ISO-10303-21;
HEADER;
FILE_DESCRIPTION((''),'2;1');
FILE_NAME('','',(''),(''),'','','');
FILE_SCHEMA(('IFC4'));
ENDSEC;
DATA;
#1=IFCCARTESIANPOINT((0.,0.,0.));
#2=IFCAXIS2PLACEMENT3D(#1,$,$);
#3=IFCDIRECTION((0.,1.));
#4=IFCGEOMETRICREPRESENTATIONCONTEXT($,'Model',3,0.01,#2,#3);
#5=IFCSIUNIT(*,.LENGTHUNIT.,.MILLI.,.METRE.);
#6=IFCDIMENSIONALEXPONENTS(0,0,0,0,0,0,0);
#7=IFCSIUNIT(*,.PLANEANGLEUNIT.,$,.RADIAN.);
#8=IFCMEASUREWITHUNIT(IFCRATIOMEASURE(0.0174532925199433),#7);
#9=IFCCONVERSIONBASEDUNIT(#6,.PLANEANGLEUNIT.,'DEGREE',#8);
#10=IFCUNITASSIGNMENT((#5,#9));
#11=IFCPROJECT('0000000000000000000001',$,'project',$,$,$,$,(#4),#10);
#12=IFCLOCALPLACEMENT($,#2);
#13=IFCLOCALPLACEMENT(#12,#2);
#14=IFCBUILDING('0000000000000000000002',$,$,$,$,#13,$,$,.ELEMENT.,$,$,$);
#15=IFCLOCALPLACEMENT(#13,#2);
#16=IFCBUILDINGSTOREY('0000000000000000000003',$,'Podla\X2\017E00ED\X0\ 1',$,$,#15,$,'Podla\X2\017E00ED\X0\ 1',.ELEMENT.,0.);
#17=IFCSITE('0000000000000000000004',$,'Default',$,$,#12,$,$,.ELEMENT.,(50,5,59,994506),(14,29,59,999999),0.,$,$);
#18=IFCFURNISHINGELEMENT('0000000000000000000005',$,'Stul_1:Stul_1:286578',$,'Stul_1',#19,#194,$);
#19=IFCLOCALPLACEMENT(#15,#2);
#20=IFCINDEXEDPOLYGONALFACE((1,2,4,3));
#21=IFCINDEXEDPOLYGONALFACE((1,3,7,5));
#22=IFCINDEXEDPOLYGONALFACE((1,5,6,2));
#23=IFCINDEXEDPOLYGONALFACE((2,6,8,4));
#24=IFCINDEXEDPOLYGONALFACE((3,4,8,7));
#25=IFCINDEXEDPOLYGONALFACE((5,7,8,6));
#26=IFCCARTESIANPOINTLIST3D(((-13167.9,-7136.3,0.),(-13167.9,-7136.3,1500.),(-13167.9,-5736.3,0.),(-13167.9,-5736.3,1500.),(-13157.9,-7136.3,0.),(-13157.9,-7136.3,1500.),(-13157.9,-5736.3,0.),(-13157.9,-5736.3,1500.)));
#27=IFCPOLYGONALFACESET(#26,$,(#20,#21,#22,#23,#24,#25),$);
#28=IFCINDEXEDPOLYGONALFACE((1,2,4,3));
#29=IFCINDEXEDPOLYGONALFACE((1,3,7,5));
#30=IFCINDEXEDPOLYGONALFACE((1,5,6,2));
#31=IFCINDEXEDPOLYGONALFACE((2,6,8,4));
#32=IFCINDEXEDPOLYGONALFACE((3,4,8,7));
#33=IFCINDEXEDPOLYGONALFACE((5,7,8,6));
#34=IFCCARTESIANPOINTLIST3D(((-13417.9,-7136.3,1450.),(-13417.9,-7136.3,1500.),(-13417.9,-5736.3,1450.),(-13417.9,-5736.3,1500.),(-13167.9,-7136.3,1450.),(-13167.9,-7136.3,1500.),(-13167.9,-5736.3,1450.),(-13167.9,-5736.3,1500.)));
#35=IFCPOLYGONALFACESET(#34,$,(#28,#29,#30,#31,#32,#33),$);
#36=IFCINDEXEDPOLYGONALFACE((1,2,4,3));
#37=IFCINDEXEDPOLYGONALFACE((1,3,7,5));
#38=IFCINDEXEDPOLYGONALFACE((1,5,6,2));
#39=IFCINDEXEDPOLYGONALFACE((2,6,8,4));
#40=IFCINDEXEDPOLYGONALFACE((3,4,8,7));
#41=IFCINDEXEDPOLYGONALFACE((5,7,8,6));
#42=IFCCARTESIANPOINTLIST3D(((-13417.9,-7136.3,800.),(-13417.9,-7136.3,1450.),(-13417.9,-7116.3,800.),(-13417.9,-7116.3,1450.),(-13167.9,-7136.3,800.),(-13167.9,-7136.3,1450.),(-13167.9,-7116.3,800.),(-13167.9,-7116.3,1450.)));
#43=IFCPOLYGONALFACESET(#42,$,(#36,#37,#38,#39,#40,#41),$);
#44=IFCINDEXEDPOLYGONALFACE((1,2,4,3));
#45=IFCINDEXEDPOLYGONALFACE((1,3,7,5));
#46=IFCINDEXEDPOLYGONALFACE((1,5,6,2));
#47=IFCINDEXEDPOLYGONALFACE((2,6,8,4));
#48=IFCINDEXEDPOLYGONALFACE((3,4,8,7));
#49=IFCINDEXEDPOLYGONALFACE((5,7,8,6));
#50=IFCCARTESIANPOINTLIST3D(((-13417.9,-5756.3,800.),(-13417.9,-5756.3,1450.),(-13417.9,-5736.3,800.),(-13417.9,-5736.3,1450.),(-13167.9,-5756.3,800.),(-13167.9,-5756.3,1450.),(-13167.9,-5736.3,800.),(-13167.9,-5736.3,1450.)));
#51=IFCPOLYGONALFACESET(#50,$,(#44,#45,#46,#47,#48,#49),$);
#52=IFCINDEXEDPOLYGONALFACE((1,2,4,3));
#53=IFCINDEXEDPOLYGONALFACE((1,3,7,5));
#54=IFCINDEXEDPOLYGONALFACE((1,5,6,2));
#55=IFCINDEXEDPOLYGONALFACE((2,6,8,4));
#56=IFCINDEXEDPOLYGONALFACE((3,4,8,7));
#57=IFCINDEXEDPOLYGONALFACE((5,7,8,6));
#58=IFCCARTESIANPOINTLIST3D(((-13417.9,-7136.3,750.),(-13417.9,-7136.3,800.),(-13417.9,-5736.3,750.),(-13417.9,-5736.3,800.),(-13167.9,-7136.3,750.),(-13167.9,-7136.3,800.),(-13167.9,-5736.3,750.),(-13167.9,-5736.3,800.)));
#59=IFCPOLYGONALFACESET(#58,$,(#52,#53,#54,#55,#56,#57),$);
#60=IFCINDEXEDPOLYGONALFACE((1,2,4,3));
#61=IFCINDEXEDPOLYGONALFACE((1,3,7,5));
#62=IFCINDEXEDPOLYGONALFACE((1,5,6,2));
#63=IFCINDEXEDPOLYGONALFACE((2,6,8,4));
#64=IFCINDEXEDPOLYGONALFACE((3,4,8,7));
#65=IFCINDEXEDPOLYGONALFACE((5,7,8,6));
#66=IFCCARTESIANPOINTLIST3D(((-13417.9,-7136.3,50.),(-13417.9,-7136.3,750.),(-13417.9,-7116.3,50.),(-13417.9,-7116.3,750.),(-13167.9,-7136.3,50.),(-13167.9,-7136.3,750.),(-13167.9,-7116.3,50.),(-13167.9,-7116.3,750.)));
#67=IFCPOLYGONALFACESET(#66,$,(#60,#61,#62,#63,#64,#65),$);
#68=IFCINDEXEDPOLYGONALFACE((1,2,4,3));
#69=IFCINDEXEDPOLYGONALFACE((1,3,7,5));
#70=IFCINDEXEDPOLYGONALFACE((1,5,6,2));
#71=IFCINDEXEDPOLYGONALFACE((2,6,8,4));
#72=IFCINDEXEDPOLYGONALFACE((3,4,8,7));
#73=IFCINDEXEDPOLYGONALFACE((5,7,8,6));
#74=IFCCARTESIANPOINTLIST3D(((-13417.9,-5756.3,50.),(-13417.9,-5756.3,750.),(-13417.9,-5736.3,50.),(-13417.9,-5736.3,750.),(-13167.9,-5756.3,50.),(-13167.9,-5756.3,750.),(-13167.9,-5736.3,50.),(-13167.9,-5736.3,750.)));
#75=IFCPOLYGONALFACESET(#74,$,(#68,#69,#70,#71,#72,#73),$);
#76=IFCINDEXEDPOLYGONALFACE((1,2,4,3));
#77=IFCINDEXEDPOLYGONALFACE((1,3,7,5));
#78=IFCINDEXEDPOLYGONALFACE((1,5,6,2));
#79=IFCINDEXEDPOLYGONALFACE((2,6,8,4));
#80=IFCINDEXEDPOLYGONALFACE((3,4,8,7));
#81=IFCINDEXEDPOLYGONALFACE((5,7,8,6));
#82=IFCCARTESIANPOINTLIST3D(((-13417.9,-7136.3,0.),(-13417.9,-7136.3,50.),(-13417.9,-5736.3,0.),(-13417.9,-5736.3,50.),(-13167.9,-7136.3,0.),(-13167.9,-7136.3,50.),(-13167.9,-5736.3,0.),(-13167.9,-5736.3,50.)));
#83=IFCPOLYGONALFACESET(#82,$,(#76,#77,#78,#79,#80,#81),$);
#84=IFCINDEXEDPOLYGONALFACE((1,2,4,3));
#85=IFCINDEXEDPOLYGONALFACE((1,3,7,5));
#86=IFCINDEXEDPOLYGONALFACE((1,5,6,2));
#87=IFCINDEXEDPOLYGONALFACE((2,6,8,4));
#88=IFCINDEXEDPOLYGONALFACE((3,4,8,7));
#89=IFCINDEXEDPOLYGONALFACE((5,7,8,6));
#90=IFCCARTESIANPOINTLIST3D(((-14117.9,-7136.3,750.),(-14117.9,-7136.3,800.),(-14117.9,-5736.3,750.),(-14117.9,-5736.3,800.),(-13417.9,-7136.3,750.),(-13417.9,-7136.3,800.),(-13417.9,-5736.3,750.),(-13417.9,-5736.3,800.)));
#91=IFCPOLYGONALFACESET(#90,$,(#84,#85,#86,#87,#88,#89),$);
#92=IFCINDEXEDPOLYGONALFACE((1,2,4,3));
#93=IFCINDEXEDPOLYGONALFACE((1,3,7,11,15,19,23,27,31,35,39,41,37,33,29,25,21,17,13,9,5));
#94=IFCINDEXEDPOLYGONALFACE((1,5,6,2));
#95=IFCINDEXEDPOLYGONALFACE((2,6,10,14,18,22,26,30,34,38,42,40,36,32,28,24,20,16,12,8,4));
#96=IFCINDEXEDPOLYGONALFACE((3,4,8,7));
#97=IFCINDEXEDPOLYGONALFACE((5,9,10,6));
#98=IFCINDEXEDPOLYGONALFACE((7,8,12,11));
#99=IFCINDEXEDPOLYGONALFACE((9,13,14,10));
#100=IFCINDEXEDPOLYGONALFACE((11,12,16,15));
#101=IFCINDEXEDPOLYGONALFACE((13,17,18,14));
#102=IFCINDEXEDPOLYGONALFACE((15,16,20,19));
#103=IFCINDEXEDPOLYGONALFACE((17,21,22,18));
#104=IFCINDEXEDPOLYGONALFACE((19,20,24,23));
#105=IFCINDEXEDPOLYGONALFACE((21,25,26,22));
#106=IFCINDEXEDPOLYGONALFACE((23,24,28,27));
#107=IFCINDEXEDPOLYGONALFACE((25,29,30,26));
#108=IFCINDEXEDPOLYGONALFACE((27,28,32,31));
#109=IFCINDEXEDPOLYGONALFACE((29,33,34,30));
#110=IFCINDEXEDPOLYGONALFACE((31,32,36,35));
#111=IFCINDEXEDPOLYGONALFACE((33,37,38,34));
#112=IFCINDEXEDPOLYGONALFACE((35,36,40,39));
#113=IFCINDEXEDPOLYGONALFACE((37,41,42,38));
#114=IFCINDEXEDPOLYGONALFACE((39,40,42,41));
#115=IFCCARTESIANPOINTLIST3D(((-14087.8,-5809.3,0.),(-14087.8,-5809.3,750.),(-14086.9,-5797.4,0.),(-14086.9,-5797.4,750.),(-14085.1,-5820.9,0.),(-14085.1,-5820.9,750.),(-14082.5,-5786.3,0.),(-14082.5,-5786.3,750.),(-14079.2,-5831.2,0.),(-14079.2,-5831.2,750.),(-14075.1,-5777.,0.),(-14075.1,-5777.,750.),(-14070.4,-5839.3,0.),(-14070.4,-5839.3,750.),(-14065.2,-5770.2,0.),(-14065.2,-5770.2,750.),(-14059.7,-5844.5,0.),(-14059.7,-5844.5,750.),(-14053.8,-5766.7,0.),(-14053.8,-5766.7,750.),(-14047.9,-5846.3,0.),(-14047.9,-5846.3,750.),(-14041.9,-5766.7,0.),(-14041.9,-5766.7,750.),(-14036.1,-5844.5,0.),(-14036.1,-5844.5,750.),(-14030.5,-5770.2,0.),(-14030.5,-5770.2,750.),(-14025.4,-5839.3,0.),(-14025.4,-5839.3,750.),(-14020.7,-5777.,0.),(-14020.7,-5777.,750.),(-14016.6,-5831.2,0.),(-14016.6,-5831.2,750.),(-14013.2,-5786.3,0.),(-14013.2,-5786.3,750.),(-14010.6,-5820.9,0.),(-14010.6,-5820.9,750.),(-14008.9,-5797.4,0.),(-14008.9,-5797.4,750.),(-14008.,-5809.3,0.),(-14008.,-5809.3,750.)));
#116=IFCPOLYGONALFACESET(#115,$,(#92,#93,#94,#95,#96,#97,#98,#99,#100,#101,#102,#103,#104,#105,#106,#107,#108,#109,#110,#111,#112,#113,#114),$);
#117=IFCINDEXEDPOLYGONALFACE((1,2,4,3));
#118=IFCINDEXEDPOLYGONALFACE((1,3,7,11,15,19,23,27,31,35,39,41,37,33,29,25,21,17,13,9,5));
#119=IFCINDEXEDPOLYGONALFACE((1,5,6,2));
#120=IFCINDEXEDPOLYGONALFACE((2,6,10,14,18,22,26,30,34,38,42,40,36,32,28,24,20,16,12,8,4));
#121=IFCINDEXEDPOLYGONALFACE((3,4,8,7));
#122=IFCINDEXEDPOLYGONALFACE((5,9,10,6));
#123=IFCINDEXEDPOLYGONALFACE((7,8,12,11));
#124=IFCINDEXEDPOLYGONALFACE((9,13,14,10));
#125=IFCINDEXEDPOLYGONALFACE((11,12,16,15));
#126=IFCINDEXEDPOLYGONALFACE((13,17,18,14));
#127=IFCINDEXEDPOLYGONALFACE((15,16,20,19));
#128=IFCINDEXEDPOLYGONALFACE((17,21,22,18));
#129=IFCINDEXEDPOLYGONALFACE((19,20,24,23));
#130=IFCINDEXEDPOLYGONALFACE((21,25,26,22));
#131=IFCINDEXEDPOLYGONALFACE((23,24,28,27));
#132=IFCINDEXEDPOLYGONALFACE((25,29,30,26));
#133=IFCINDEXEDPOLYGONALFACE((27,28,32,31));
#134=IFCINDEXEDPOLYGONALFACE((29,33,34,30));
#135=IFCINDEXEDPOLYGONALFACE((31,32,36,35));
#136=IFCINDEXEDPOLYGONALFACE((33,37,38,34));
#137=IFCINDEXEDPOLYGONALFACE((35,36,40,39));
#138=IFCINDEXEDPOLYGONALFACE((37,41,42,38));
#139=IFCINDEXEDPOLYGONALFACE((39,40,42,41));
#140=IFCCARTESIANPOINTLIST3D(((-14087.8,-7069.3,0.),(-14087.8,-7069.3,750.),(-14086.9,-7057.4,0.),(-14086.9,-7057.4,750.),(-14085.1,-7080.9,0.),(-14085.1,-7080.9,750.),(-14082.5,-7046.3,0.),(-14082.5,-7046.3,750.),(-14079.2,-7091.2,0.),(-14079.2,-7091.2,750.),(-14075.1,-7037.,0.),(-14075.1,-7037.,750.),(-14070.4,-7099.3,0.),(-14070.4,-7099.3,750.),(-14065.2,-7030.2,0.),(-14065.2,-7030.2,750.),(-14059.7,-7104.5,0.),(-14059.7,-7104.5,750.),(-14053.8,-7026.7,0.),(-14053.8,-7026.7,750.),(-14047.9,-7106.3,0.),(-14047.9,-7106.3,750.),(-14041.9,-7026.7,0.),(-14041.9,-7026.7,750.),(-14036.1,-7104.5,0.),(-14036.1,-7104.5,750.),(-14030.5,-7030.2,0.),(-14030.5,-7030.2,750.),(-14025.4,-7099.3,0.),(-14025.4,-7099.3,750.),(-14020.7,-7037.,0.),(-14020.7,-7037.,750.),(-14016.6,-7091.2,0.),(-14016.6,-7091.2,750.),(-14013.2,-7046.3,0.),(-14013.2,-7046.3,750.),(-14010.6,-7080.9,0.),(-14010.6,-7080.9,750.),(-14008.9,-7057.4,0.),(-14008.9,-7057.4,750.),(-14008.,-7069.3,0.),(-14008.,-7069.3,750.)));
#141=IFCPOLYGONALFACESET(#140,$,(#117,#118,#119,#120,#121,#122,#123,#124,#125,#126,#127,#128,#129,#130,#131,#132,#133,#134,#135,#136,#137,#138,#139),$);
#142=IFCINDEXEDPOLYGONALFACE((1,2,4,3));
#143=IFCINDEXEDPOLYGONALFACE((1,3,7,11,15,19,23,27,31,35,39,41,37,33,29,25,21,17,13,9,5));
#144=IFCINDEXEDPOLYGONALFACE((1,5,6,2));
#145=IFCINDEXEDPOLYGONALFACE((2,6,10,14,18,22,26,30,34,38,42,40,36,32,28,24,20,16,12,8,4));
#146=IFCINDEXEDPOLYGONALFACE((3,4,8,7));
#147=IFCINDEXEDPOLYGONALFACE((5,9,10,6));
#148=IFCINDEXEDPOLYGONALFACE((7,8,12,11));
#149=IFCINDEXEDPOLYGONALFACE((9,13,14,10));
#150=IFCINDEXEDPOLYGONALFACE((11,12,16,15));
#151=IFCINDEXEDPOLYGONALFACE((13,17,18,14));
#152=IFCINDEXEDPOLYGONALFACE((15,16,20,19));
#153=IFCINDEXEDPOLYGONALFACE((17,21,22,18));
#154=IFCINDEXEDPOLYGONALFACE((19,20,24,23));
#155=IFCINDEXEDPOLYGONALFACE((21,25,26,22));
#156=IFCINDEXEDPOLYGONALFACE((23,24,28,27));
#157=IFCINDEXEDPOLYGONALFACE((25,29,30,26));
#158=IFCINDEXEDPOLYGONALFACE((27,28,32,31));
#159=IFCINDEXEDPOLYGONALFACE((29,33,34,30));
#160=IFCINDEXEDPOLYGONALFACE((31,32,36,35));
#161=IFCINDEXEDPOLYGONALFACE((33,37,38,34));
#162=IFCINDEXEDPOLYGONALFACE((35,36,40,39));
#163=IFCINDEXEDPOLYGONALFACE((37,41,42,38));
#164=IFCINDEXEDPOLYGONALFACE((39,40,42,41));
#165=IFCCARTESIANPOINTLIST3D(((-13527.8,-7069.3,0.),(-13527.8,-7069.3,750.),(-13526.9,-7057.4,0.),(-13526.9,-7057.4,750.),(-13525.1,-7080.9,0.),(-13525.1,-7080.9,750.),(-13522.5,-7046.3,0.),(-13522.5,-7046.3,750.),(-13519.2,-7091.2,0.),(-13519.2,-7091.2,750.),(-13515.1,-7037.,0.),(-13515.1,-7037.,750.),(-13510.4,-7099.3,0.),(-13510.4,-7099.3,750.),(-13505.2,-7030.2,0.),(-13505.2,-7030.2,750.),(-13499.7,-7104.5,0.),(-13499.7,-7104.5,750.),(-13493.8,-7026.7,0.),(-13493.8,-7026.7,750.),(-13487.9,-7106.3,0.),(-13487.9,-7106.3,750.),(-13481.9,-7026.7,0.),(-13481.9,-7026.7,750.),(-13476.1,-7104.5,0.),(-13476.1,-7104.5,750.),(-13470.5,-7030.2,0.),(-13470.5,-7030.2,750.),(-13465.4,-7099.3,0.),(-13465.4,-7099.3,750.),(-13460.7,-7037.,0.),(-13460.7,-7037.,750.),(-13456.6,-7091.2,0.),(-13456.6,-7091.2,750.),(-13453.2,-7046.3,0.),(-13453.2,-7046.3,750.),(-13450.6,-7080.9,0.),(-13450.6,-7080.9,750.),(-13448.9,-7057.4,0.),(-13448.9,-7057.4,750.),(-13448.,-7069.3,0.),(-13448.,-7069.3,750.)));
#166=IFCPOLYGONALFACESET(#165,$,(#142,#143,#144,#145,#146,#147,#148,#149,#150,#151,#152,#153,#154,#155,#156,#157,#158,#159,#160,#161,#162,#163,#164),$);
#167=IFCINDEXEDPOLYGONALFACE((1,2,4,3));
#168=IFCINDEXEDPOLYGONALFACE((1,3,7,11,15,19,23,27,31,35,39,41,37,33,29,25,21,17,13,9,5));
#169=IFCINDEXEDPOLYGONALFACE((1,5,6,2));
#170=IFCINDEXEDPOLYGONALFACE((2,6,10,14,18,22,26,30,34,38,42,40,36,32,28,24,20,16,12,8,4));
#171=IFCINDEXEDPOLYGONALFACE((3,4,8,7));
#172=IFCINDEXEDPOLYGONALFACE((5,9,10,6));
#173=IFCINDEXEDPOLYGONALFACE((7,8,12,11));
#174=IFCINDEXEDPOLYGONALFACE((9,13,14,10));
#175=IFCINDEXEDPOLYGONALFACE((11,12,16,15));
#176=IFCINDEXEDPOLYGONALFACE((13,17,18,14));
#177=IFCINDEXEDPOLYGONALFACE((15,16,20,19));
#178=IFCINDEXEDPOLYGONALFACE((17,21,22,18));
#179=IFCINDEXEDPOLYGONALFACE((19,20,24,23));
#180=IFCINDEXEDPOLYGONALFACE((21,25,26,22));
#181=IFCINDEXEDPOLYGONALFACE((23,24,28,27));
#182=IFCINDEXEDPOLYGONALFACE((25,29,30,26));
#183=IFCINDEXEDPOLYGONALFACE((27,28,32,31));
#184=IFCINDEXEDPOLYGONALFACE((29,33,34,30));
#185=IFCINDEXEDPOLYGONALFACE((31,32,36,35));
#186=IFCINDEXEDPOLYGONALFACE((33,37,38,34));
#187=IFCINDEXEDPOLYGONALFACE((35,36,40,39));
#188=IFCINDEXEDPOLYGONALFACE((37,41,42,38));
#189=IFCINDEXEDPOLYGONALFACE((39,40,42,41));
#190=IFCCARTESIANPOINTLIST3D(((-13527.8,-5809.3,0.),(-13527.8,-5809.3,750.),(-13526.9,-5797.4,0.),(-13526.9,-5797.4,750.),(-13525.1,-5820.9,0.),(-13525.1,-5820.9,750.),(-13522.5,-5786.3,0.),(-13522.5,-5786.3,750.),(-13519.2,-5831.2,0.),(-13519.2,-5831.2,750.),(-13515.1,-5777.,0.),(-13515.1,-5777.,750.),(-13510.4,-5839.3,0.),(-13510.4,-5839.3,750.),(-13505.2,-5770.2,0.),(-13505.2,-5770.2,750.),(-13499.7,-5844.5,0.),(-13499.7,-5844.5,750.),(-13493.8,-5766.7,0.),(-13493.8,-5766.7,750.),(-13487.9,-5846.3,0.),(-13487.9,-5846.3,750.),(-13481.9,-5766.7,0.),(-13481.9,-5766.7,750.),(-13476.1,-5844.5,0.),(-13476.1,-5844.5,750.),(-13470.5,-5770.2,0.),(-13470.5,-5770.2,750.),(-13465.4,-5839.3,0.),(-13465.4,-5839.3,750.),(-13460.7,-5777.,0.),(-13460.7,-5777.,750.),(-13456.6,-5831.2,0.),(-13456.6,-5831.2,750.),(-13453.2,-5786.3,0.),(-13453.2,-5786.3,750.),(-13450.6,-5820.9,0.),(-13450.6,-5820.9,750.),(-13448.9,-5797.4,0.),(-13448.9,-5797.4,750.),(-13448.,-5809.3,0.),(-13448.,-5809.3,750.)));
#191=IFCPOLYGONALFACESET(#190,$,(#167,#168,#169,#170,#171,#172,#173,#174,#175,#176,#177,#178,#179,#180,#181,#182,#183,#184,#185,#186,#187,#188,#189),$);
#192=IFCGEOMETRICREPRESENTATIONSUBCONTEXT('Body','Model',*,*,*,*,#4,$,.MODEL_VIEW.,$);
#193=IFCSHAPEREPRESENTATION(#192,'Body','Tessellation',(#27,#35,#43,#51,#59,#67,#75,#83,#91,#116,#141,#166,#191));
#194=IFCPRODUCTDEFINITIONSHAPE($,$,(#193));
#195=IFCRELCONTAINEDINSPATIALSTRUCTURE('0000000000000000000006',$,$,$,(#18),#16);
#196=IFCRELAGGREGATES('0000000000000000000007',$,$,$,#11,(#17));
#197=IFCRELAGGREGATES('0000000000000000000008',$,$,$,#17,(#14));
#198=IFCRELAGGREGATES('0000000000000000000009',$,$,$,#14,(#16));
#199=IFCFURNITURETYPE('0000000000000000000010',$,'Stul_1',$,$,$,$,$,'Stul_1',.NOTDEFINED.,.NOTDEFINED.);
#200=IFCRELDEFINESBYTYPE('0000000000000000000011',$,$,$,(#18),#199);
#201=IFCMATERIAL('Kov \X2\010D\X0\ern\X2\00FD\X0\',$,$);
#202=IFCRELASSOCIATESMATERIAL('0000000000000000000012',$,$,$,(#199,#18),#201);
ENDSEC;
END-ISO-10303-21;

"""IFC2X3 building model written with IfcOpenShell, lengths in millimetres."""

from ifc_helpers import new_model, entity, si_unit, converted_unit, direction, frame, frame_2d, origin, origin_2d_with_axis, place, context, subcontext, project, spatial, rectangle, circle, extrude, source, transform, mapped, material, type_object, type_shapes, element, save


model = new_model("IFC2X3")

# Units and contexts
model_context = context("Model", 3, precision=0.01, world=origin(), true_north=direction((0.0, 1.0)))
body_context = subcontext(model_context, "Body", "Model", "MODEL_VIEW")
ifc_project = project(units=[si_unit("LENGTHUNIT", "METRE", prefix="MILLI"), converted_unit("PLANEANGLEUNIT", "DEGREE", entity("IfcRatioMeasure", 0.0174532925199433), si_unit("PLANEANGLEUNIT", "RADIAN"), dimensions=[0, 0, 0, 0, 0, 0, 0])], contexts=[model_context])

# Site, building, storey
site_placement = place(None, origin())
site = spatial("IfcSite", under=ifc_project, at=site_placement, Name="Default", CompositionType="ELEMENT", RefLatitude=(50, 5, 59, 994506), RefLongitude=(14, 29, 59, 999999), RefElevation=0.0)
building_placement = place(site_placement, origin())
building = spatial("IfcBuilding", under=site, at=building_placement, CompositionType="ELEMENT")
storey_placement = place(building_placement, origin())
storey = spatial("IfcBuildingStorey", under=building, at=storey_placement, Name="Podlaží 1", LongName="Podlaží 1", CompositionType="ELEMENT", Elevation=0.0)

# Furnishing element
ifc_material_1 = material(Name="Kov černý")
furniture_type = type_object("IfcFurnitureType", Name="Stul_1", ElementType="Stul_1", material=ifc_material_1)
shared_shape_1 = source(origin(), body_context, "Body", "SweptSolid", [
    extrude(rectangle(XDim=1400.0, YDim=10.0, at=origin_2d_with_axis()), frame((0.0, 605.0, 0.0), z_axis=(0.0, 0.0, 1.0), x_axis=(-1.0, 0.0, 0.0)), (0.0, 0.0, 1.0), 1500.0),
    extrude(rectangle(XDim=1400.0, YDim=250.0, at=frame_2d((0.0, 0.0), x_axis=(1.0, 0.0))), frame((0.0, 475.0, 1450.0), z_axis=(0.0, 0.0, 1.0), x_axis=(-1.0, 0.0, 0.0)), (0.0, 0.0, 1.0), 50.0),
    extrude(rectangle(XDim=20.0, YDim=250.0, at=origin_2d_with_axis()), frame((690.0, 475.0, 800.0), z_axis=(0.0, 0.0, 1.0), x_axis=(-1.0, 0.0, 0.0)), (0.0, 0.0, 1.0), 650.0),
    extrude(rectangle(XDim=20.0, YDim=250.0, at=frame_2d((0.0, 0.0), x_axis=(1.0, 0.0))), frame((-690.0, 475.0, 800.0), z_axis=(0.0, 0.0, 1.0), x_axis=(-1.0, 0.0, 0.0)), (0.0, 0.0, 1.0), 650.0),
    extrude(rectangle(XDim=1400.0, YDim=250.0, at=origin_2d_with_axis()), frame((0.0, 475.0, 750.0), z_axis=(0.0, 0.0, 1.0), x_axis=(-1.0, 0.0, 0.0)), (0.0, 0.0, 1.0), 50.0),
    extrude(rectangle(XDim=20.0, YDim=250.0, at=origin_2d_with_axis()), frame((690.0, 475.0, 50.0), z_axis=(0.0, 0.0, 1.0), x_axis=(-1.0, 0.0, 0.0)), (0.0, 0.0, 1.0), 700.0),
    extrude(rectangle(XDim=20.0, YDim=250.0, at=frame_2d((0.0, 0.0), x_axis=(1.0, 0.0))), frame((-690.0, 475.0, 50.0), z_axis=(0.0, 0.0, 1.0), x_axis=(-1.0, 0.0, 0.0)), (0.0, 0.0, 1.0), 700.0),
    extrude(rectangle(XDim=1400.0, YDim=250.0, at=origin_2d_with_axis()), frame((0.0, 475.0, 0.0), z_axis=(0.0, 0.0, 1.0), x_axis=(-1.0, 0.0, 0.0)), (0.0, 0.0, 1.0), 50.0),
    extrude(rectangle(XDim=1400.0, YDim=700.0, at=origin_2d_with_axis()), frame((0.0, 0.0, 750.0), z_axis=(0.0, 0.0, 1.0), x_axis=(-1.0, 0.0, 0.0)), (0.0, 0.0, 1.0), 50.0),
    extrude(circle(Radius=40.0, at=frame_2d((0.0, 0.0), x_axis=(1.0, 0.0))), frame((-630.0, -280.0, 0.0)), (0.0, 0.0, 1.0), 750.0),
    extrude(circle(Radius=40.0, at=frame_2d((0.0, 0.0), x_axis=(1.0, 0.0))), frame((630.0, -280.0, 0.0)), (0.0, 0.0, 1.0), 750.0),
    extrude(circle(Radius=40.0, at=frame_2d((0.0, 0.0), x_axis=(1.0, 0.0))), frame((630.0, 280.0, 0.0)), (0.0, 0.0, 1.0), 750.0),
    extrude(circle(Radius=40.0, at=frame_2d((0.0, 0.0), x_axis=(1.0, 0.0))), frame((-630.0, 280.0, 0.0)), (0.0, 0.0, 1.0), 750.0),
])
type_shapes(furniture_type, [shared_shape_1])
for number, where, z_axis, x_axis, name in (
    (1, (-13767.9, -6436.3, 0.0), (0.0, 0.0, 1.0), (0.0, -1.0, 0.0), "Stul_1:Stul_1:286578"),
):
    element("IfcFurnishingElement", number, at=place(storey_placement, frame(where, z_axis=z_axis, x_axis=x_axis)), inside=storey, type_object=furniture_type, material=ifc_material_1, Name=name, ObjectType="Stul_1", context=body_context, shape_type="MappedRepresentation", body=[
        mapped(shared_shape_1, transform((0.0, 0.0, 0.0), scale=1.0)),
    ])

save(model, "model.ifc")
